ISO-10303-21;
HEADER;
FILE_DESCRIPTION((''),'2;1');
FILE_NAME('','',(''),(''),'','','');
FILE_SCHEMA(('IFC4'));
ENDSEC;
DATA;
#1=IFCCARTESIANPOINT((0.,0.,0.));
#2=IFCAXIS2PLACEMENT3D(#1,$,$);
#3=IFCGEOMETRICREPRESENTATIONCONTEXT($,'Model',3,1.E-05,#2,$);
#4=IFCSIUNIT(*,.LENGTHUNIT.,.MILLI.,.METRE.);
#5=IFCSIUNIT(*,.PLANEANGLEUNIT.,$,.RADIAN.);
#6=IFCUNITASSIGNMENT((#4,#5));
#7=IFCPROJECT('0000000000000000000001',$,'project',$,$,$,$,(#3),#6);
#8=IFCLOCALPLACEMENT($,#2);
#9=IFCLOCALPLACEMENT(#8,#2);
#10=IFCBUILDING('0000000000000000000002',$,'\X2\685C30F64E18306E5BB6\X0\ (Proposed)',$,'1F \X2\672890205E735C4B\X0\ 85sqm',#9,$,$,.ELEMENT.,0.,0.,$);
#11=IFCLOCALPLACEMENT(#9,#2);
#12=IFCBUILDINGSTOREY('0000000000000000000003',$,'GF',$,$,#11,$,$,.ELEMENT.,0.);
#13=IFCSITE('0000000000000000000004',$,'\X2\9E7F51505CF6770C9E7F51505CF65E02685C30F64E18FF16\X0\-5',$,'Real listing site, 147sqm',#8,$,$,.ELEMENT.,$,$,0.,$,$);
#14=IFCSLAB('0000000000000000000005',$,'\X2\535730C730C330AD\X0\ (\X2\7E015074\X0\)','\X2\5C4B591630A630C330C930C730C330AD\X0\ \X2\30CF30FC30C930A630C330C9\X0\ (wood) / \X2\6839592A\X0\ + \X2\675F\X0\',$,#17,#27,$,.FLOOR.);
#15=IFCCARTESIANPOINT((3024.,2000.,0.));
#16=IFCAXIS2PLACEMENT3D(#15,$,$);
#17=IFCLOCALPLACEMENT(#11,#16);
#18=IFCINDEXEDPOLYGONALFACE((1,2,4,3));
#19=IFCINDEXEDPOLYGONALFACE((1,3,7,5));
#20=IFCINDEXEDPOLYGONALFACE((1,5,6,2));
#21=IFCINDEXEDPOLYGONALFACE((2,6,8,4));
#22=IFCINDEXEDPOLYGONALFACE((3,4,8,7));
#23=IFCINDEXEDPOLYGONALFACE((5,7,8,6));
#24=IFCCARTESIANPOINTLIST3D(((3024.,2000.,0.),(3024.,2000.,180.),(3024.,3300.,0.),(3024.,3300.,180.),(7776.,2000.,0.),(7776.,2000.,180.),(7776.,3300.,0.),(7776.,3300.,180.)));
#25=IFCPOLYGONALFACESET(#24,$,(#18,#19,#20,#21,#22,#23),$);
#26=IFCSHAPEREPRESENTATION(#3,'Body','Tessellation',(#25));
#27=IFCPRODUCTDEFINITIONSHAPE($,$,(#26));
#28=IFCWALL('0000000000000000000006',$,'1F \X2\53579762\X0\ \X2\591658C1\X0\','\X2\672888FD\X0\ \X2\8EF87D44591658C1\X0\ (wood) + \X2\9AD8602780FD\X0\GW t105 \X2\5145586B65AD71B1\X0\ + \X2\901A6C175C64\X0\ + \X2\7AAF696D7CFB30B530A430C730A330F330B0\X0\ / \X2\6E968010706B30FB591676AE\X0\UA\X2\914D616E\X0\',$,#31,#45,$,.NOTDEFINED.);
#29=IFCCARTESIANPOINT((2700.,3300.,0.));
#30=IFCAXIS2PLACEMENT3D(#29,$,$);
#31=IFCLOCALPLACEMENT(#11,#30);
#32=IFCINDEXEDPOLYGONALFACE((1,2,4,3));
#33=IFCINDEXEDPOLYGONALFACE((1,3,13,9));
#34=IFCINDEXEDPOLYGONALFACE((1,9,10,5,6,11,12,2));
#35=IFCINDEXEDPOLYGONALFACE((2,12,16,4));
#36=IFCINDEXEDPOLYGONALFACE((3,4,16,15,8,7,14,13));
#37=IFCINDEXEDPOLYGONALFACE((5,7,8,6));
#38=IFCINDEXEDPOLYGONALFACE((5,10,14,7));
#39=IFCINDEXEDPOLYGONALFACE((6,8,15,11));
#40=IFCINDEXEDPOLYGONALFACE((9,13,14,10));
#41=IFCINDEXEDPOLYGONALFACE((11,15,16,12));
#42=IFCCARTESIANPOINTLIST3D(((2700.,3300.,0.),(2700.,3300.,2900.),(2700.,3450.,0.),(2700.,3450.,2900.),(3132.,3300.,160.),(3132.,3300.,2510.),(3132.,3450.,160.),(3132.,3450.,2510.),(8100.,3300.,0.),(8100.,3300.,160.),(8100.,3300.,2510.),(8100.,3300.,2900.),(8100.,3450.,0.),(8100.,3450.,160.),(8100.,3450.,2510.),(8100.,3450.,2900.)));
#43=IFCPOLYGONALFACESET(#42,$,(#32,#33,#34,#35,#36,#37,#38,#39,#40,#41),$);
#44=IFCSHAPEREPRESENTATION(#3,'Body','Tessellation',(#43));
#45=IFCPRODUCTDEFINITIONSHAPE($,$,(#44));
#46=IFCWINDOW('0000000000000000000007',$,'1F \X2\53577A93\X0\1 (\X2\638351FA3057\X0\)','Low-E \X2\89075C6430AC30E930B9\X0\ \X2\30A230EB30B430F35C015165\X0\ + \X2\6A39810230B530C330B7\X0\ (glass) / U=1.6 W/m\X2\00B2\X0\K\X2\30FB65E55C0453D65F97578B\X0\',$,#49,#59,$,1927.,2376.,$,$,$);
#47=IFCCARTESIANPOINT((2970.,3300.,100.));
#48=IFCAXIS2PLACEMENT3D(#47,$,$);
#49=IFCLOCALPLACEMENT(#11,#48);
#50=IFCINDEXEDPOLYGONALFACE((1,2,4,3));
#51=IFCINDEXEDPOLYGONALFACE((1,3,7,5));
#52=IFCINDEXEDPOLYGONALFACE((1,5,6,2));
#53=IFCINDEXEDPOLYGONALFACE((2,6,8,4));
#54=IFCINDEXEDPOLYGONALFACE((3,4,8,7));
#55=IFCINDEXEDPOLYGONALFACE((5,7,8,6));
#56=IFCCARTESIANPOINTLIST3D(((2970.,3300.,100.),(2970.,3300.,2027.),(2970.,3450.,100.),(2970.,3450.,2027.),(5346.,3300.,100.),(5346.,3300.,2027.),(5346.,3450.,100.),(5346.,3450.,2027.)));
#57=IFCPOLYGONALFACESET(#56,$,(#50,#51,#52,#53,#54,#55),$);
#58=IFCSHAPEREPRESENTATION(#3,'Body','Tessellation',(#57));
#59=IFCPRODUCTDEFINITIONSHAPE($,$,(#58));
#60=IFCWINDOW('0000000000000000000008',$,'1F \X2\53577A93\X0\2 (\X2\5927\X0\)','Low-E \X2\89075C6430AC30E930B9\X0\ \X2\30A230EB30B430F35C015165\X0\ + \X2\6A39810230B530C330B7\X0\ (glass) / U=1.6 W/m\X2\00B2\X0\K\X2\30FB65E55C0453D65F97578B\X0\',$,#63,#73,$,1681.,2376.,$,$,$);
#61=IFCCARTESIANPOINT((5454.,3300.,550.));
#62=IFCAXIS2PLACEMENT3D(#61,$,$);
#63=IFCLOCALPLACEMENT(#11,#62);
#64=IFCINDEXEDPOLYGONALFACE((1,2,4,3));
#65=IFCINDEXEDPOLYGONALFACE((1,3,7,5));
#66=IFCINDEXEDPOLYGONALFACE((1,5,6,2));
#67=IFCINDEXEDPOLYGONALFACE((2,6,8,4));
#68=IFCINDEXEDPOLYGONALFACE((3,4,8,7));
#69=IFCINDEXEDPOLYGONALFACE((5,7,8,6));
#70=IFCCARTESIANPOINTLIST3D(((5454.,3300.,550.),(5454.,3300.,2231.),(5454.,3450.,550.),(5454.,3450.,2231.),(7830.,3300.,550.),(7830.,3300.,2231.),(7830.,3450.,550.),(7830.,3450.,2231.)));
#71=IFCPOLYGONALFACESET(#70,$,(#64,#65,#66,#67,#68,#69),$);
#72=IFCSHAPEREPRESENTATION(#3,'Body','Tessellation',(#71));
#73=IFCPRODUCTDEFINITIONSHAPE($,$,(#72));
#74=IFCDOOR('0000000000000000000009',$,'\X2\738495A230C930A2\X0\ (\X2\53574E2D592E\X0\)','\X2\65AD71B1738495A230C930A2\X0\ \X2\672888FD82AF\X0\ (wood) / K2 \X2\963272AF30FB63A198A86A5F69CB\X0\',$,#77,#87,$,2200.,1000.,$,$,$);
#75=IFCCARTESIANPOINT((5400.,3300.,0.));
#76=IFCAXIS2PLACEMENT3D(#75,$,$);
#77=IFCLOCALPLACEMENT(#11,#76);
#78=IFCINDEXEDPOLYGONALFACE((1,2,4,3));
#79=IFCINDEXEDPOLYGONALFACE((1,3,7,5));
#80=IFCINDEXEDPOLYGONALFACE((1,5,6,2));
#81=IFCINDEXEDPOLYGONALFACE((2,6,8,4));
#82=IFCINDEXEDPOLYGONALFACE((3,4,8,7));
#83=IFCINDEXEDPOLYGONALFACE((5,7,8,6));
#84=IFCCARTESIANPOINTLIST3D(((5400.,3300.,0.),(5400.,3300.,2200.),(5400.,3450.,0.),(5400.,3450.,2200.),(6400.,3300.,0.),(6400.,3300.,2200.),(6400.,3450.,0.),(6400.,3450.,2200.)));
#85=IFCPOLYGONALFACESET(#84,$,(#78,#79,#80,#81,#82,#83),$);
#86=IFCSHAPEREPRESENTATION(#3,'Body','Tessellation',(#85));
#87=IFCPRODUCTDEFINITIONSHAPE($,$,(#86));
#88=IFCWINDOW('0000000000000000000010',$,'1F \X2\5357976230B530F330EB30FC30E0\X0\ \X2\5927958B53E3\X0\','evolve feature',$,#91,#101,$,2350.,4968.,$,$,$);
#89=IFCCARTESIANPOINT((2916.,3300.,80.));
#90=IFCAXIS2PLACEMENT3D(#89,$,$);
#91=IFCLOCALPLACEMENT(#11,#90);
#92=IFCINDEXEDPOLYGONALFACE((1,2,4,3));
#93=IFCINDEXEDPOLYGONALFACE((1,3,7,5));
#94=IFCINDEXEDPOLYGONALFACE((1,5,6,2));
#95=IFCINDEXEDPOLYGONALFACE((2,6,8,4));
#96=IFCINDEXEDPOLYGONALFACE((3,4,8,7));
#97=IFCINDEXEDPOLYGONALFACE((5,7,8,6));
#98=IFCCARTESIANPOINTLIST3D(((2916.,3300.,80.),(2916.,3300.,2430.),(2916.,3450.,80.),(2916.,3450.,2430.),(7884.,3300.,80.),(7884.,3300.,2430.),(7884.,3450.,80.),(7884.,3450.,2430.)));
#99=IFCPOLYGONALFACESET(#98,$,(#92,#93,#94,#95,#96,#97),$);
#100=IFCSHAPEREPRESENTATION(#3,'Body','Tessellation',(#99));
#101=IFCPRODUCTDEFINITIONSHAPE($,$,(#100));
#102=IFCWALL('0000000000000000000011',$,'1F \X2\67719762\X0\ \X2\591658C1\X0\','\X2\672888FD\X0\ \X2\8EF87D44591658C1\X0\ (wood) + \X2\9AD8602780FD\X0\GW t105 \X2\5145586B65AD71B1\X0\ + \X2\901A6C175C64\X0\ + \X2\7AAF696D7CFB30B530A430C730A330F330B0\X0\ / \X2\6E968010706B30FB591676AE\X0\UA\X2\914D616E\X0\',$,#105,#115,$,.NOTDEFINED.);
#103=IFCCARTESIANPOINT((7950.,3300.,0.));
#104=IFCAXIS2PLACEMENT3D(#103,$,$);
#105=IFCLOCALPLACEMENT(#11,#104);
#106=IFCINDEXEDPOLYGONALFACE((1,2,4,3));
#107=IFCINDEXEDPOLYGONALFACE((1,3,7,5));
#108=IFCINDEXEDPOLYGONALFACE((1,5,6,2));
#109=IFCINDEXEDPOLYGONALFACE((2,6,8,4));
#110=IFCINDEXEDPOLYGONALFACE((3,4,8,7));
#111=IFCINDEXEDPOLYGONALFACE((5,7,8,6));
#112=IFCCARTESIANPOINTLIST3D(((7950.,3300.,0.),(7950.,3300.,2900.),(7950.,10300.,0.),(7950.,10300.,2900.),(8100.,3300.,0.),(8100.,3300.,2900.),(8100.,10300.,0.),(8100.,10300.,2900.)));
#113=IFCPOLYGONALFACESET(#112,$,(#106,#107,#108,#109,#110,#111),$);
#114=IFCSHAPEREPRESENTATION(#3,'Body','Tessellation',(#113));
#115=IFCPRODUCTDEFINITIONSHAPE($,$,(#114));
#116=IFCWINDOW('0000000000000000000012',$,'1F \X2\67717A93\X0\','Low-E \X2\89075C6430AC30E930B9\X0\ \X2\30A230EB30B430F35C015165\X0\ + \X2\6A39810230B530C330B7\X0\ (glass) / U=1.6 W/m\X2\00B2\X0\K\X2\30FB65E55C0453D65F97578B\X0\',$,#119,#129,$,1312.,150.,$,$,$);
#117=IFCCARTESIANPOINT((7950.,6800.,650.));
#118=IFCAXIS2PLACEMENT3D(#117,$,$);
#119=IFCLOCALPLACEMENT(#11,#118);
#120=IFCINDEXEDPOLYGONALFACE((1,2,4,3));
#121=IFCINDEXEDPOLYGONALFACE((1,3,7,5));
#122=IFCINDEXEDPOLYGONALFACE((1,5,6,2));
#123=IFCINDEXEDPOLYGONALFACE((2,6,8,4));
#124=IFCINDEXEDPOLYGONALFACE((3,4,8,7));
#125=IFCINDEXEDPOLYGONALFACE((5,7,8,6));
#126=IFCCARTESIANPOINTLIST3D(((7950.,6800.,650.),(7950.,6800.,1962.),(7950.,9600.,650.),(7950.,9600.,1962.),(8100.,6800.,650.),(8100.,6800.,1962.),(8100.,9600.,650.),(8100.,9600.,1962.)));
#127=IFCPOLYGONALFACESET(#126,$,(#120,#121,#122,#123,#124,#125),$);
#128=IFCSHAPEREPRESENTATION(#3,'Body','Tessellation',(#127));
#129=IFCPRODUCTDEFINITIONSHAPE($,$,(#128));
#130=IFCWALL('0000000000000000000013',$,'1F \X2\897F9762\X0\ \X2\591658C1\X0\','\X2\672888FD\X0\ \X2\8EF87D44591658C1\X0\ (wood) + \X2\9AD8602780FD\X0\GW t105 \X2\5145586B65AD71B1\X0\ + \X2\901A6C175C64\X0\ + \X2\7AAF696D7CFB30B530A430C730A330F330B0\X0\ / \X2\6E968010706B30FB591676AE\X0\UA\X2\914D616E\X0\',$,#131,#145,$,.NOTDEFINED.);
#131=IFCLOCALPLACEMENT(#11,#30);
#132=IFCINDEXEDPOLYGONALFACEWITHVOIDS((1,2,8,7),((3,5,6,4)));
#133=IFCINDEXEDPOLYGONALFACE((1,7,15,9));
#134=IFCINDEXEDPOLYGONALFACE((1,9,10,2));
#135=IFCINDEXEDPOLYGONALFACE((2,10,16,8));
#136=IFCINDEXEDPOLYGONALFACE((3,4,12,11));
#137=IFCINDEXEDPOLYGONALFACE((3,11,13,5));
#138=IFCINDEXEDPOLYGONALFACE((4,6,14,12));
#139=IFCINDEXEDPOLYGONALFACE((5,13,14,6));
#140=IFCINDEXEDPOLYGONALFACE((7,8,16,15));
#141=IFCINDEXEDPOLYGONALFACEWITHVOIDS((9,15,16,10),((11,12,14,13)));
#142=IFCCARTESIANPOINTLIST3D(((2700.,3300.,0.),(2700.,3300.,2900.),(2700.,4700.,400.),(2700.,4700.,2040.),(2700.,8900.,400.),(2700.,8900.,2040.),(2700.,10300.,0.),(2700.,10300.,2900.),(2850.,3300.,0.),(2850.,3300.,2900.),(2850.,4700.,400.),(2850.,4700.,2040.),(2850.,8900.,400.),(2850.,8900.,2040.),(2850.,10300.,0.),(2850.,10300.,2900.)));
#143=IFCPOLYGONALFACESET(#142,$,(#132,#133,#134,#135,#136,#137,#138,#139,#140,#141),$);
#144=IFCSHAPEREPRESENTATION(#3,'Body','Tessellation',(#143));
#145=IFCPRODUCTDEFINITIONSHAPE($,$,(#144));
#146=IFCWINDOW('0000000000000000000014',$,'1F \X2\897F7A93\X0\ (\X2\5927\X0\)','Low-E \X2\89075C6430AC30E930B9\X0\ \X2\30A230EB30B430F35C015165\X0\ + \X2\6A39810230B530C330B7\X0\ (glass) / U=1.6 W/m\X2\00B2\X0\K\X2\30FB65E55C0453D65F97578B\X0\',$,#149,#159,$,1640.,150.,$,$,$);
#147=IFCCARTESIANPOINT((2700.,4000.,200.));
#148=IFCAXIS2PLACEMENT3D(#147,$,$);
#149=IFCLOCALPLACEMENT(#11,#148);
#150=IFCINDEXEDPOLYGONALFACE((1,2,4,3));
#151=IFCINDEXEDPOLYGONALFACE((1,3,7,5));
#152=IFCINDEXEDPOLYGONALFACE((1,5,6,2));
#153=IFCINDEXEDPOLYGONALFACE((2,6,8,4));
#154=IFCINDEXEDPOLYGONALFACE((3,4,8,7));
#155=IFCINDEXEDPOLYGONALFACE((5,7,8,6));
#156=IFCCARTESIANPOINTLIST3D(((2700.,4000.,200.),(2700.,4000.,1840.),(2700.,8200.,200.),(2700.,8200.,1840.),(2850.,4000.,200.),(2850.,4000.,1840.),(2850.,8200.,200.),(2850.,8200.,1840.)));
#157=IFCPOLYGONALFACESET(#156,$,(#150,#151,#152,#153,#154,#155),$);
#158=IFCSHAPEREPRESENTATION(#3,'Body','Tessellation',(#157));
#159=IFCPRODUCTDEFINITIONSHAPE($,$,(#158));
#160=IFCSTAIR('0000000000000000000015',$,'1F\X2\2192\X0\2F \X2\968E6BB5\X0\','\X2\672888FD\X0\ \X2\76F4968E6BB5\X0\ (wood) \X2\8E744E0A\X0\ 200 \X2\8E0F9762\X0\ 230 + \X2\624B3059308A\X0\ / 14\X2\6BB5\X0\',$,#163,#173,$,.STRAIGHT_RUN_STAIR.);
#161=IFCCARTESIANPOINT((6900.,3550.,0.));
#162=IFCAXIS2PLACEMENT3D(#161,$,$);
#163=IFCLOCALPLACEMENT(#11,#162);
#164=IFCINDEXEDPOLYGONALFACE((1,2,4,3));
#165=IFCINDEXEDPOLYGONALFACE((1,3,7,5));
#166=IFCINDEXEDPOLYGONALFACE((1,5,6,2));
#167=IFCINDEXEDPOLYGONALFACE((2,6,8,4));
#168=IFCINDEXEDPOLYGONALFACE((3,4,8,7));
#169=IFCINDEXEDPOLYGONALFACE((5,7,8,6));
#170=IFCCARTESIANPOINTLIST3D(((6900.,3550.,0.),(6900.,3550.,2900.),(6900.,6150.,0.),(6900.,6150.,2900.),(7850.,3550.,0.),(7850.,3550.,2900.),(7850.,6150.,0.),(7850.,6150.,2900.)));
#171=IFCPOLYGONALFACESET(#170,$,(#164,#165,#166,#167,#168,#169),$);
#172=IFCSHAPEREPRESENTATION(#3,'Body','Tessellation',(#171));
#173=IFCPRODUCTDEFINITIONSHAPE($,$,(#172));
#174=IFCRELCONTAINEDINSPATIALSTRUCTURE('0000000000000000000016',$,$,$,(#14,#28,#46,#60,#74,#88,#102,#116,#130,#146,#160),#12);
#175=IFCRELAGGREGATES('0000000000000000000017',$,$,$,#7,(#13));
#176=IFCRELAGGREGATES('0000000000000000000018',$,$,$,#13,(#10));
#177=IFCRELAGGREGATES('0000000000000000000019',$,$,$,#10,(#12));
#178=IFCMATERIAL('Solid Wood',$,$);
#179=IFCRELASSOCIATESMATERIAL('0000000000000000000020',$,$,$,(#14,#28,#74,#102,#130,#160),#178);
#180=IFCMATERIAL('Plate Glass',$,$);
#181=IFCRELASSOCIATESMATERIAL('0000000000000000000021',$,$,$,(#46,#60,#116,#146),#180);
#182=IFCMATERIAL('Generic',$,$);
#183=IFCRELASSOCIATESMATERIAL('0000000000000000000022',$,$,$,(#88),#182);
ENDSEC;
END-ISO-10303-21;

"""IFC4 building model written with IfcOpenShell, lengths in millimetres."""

from ifc_helpers import new_model, si_unit, frame, frame_2d, origin, place, context, project, spatial, rectangle, extrude, material, element, fill, save


model = new_model("IFC4")

# Units and contexts
model_context = context("Model", 3, precision=1e-05, world=origin())
ifc_project = project(units=[si_unit("LENGTHUNIT", "METRE", prefix="MILLI"), si_unit("PLANEANGLEUNIT", "RADIAN")], contexts=[model_context])

# Site, building, storey
site_placement = place(None, origin())
site = spatial("IfcSite", under=ifc_project, at=site_placement, Name="鹿児島県鹿児島市桜ヶ丘６-5", ObjectType="Real listing site, 147sqm", CompositionType="ELEMENT", RefElevation=0.0)
building_placement = place(site_placement, origin())
building = spatial("IfcBuilding", under=site, at=building_placement, Name="桜ヶ丘の家 (Proposed)", ObjectType="1F 木造平屋 85sqm", CompositionType="ELEMENT", ElevationOfRefHeight=0.0, ElevationOfTerrain=0.0)
storey_placement = place(building_placement, origin())
storey = spatial("IfcBuildingStorey", under=building, at=storey_placement, Name="GF", CompositionType="ELEMENT", Elevation=0.0)

# Slab
ifc_material_1 = material(Name="Solid Wood")
slab_1_placement = place(storey_placement, frame((3024.0, 2000.0, 0.0)))
element("IfcSlab", 1, at=slab_1_placement, inside=storey, material=ifc_material_1, Name="南デッキ (縁側)", Description="屋外ウッドデッキ ハードウッド (wood) / 根太 + 束", PredefinedType="FLOOR", context=model_context, shape_type="SweptSolid", body=[
    extrude(rectangle(XDim=4752.0, YDim=1300.0, at=frame_2d((2376.0, 650.0))), frame((3024.0, 2000.0, 0.0)), (0.0, 0.0, 1.0), 180.0),
])
ifc_material_2 = material(Name="Generic")

# Wall, openings, windows, door
wall_1_placement = place(storey_placement, frame((2700.0, 3300.0, 0.0)))
wall_1 = element("IfcWall", 2, at=wall_1_placement, inside=storey, material=ifc_material_1, Name="1F 南面 外壁", Description="木製 軸組外壁 (wood) + 高性能GW t105 充填断熱 + 通気層 + 窯業系サイディング / 準耐火・外皮UA配慮", PredefinedType="NOTDEFINED", context=model_context, shape_type="SweptSolid", body=[
    extrude(rectangle(XDim=5400.0, YDim=150.0, at=frame_2d((2700.0, 75.0))), frame((2700.0, 3300.0, 0.0)), (0.0, 0.0, 1.0), 2900.0),
])
opening_1_placement = place(storey_placement, frame((2970.0, 3300.0, 100.0)))
opening_1 = element("IfcOpeningElement", 3, at=opening_1_placement, cuts=wall_1, PredefinedType="NOTDEFINED", context=model_context, shape_type="SweptSolid", body=[
    extrude(rectangle(XDim=2376.0, YDim=150.0, at=frame_2d((1188.0, 75.0))), frame((2970.0, 3300.0, 100.0)), (0.0, 0.0, 1.0), 1927.0),
])
opening_2_placement = place(storey_placement, frame((5454.0, 3300.0, 550.0)))
opening_2 = element("IfcOpeningElement", 4, at=opening_2_placement, cuts=wall_1, PredefinedType="NOTDEFINED", context=model_context, shape_type="SweptSolid", body=[
    extrude(rectangle(XDim=2376.0, YDim=150.0, at=frame_2d((1188.0, 75.0))), frame((5454.0, 3300.0, 550.0)), (0.0, 0.0, 1.0), 1681.0),
])
opening_3_placement = place(storey_placement, frame((5400.0, 3300.0, 0.0)))
opening_3 = element("IfcOpeningElement", 5, at=opening_3_placement, cuts=wall_1, PredefinedType="NOTDEFINED", context=model_context, shape_type="SweptSolid", body=[
    extrude(rectangle(XDim=1000.0, YDim=150.0, at=frame_2d((500.0, 75.0))), frame((5400.0, 3300.0, 0.0)), (0.0, 0.0, 1.0), 2200.0),
])
opening_4_placement = place(storey_placement, frame((2916.0, 3300.0, 80.0)))
opening_4 = element("IfcOpeningElement", 6, at=opening_4_placement, cuts=wall_1, PredefinedType="NOTDEFINED", context=model_context, shape_type="SweptSolid", body=[
    extrude(rectangle(XDim=4968.0, YDim=150.0, at=frame_2d((2484.0, 75.0))), frame((2916.0, 3300.0, 80.0)), (0.0, 0.0, 1.0), 2350.0),
])
ifc_material_3 = material(Name="Plate Glass")
window_1_placement = place(storey_placement, frame((2970.0, 3300.0, 100.0)))
window_1 = element("IfcWindow", 7, at=window_1_placement, inside=storey, material=ifc_material_3, Name="1F 南窓1 (掃出し)", Description="Low-E 複層ガラス アルゴン封入 + 樹脂サッシ (glass) / U=1.6 W/m²K・日射取得型", OverallHeight=1927.0, OverallWidth=2376.0, context=model_context, shape_type="SweptSolid", body=[
    extrude(rectangle(XDim=2376.0, YDim=150.0, at=frame_2d((1188.0, 75.0))), frame((2970.0, 3300.0, 100.0)), (0.0, 0.0, 1.0), 1927.0),
])
fill(opening_1, window_1)
window_2_placement = place(storey_placement, frame((5454.0, 3300.0, 550.0)))
window_2 = element("IfcWindow", 8, at=window_2_placement, inside=storey, material=ifc_material_3, Name="1F 南窓2 (大)", Description="Low-E 複層ガラス アルゴン封入 + 樹脂サッシ (glass) / U=1.6 W/m²K・日射取得型", OverallHeight=1681.0, OverallWidth=2376.0, context=model_context, shape_type="SweptSolid", body=[
    extrude(rectangle(XDim=2376.0, YDim=150.0, at=frame_2d((1188.0, 75.0))), frame((5454.0, 3300.0, 550.0)), (0.0, 0.0, 1.0), 1681.0),
])
fill(opening_2, window_2)
door_placement = place(storey_placement, frame((5400.0, 3300.0, 0.0)))
door = element("IfcDoor", 9, at=door_placement, inside=storey, material=ifc_material_1, Name="玄関ドア (南中央)", Description="断熱玄関ドア 木製芯 (wood) / K2 防犯・採風機構", OverallHeight=2200.0, OverallWidth=1000.0, context=model_context, shape_type="SweptSolid", body=[
    extrude(rectangle(XDim=1000.0, YDim=150.0, at=frame_2d((500.0, 75.0))), frame((5400.0, 3300.0, 0.0)), (0.0, 0.0, 1.0), 2200.0),
])
fill(opening_3, door)
window_3_placement = place(storey_placement, frame((2916.0, 3300.0, 80.0)))
window_3 = element("IfcWindow", 10, at=window_3_placement, inside=storey, material=ifc_material_2, Name="1F 南面サンルーム 大開口", Description="evolve feature", OverallHeight=2350.0, OverallWidth=4968.0, context=model_context, shape_type="SweptSolid", body=[
    extrude(rectangle(XDim=4968.0, YDim=150.0, at=frame_2d((2484.0, 75.0))), frame((2916.0, 3300.0, 80.0)), (0.0, 0.0, 1.0), 2350.0),
])
fill(opening_4, window_3)

# Walls, openings, windows
wall_2_placement = place(storey_placement, frame((7950.0, 3300.0, 0.0)))
wall_2 = element("IfcWall", 11, at=wall_2_placement, inside=storey, material=ifc_material_1, Name="1F 東面 外壁", Description="木製 軸組外壁 (wood) + 高性能GW t105 充填断熱 + 通気層 + 窯業系サイディング / 準耐火・外皮UA配慮", PredefinedType="NOTDEFINED", context=model_context, shape_type="SweptSolid", body=[
    extrude(rectangle(XDim=150.0, YDim=7000.0, at=frame_2d((75.0, 3500.0))), frame((7950.0, 3300.0, 0.0)), (0.0, 0.0, 1.0), 2900.0),
])
opening_5_placement = place(storey_placement, frame((7950.0, 6800.0, 650.0)))
opening_5 = element("IfcOpeningElement", 12, at=opening_5_placement, cuts=wall_2, PredefinedType="NOTDEFINED", context=model_context, shape_type="SweptSolid", body=[
    extrude(rectangle(XDim=150.0, YDim=2800.0, at=frame_2d((75.0, 1400.0))), frame((7950.0, 6800.0, 650.0)), (0.0, 0.0, 1.0), 1312.0),
])
window_4_placement = place(storey_placement, frame((7950.0, 6800.0, 650.0)))
window_4 = element("IfcWindow", 13, at=window_4_placement, inside=storey, material=ifc_material_3, Name="1F 東窓", Description="Low-E 複層ガラス アルゴン封入 + 樹脂サッシ (glass) / U=1.6 W/m²K・日射取得型", OverallHeight=1312.0, OverallWidth=150.0, context=model_context, shape_type="SweptSolid", body=[
    extrude(rectangle(XDim=150.0, YDim=2800.0, at=frame_2d((75.0, 1400.0))), frame((7950.0, 6800.0, 650.0)), (0.0, 0.0, 1.0), 1312.0),
])
fill(opening_5, window_4)
wall_3_placement = place(storey_placement, frame((2700.0, 3300.0, 0.0)))
wall_3 = element("IfcWall", 14, at=wall_3_placement, inside=storey, material=ifc_material_1, Name="1F 西面 外壁", Description="木製 軸組外壁 (wood) + 高性能GW t105 充填断熱 + 通気層 + 窯業系サイディング / 準耐火・外皮UA配慮", PredefinedType="NOTDEFINED", context=model_context, shape_type="SweptSolid", body=[
    extrude(rectangle(XDim=150.0, YDim=7000.0, at=frame_2d((75.0, 3500.0))), frame((2700.0, 3300.0, 0.0)), (0.0, 0.0, 1.0), 2900.0),
])
opening_6_placement = place(storey_placement, frame((2700.0, 4000.0, 200.0)))
opening_6 = element("IfcOpeningElement", 15, at=opening_6_placement, cuts=wall_3, PredefinedType="NOTDEFINED", context=model_context, shape_type="SweptSolid", body=[
    extrude(rectangle(XDim=150.0, YDim=4200.0, at=frame_2d((75.0, 2100.0))), frame((2700.0, 4000.0, 200.0)), (0.0, 0.0, 1.0), 1640.0),
])
window_5_placement = place(storey_placement, frame((2700.0, 4000.0, 200.0)))
window_5 = element("IfcWindow", 16, at=window_5_placement, inside=storey, material=ifc_material_3, Name="1F 西窓 (大)", Description="Low-E 複層ガラス アルゴン封入 + 樹脂サッシ (glass) / U=1.6 W/m²K・日射取得型", OverallHeight=1640.0, OverallWidth=150.0, context=model_context, shape_type="SweptSolid", body=[
    extrude(rectangle(XDim=150.0, YDim=4200.0, at=frame_2d((75.0, 2100.0))), frame((2700.0, 4000.0, 200.0)), (0.0, 0.0, 1.0), 1640.0),
])
fill(opening_6, window_5)

# Stair
stair_placement = place(storey_placement, frame((6900.0, 3550.0, 0.0)))
element("IfcStair", 17, at=stair_placement, inside=storey, material=ifc_material_1, Name="1F→2F 階段", Description="木製 直階段 (wood) 蹴上 200 踏面 230 + 手すり / 14段", PredefinedType="STRAIGHT_RUN_STAIR", context=model_context, shape_type="SweptSolid", body=[
    extrude(rectangle(XDim=950.0, YDim=2600.0, at=frame_2d((475.0, 1300.0))), frame((6900.0, 3550.0, 0.0)), (0.0, 0.0, 1.0), 2900.0),
])

save(model, "model.ifc")
